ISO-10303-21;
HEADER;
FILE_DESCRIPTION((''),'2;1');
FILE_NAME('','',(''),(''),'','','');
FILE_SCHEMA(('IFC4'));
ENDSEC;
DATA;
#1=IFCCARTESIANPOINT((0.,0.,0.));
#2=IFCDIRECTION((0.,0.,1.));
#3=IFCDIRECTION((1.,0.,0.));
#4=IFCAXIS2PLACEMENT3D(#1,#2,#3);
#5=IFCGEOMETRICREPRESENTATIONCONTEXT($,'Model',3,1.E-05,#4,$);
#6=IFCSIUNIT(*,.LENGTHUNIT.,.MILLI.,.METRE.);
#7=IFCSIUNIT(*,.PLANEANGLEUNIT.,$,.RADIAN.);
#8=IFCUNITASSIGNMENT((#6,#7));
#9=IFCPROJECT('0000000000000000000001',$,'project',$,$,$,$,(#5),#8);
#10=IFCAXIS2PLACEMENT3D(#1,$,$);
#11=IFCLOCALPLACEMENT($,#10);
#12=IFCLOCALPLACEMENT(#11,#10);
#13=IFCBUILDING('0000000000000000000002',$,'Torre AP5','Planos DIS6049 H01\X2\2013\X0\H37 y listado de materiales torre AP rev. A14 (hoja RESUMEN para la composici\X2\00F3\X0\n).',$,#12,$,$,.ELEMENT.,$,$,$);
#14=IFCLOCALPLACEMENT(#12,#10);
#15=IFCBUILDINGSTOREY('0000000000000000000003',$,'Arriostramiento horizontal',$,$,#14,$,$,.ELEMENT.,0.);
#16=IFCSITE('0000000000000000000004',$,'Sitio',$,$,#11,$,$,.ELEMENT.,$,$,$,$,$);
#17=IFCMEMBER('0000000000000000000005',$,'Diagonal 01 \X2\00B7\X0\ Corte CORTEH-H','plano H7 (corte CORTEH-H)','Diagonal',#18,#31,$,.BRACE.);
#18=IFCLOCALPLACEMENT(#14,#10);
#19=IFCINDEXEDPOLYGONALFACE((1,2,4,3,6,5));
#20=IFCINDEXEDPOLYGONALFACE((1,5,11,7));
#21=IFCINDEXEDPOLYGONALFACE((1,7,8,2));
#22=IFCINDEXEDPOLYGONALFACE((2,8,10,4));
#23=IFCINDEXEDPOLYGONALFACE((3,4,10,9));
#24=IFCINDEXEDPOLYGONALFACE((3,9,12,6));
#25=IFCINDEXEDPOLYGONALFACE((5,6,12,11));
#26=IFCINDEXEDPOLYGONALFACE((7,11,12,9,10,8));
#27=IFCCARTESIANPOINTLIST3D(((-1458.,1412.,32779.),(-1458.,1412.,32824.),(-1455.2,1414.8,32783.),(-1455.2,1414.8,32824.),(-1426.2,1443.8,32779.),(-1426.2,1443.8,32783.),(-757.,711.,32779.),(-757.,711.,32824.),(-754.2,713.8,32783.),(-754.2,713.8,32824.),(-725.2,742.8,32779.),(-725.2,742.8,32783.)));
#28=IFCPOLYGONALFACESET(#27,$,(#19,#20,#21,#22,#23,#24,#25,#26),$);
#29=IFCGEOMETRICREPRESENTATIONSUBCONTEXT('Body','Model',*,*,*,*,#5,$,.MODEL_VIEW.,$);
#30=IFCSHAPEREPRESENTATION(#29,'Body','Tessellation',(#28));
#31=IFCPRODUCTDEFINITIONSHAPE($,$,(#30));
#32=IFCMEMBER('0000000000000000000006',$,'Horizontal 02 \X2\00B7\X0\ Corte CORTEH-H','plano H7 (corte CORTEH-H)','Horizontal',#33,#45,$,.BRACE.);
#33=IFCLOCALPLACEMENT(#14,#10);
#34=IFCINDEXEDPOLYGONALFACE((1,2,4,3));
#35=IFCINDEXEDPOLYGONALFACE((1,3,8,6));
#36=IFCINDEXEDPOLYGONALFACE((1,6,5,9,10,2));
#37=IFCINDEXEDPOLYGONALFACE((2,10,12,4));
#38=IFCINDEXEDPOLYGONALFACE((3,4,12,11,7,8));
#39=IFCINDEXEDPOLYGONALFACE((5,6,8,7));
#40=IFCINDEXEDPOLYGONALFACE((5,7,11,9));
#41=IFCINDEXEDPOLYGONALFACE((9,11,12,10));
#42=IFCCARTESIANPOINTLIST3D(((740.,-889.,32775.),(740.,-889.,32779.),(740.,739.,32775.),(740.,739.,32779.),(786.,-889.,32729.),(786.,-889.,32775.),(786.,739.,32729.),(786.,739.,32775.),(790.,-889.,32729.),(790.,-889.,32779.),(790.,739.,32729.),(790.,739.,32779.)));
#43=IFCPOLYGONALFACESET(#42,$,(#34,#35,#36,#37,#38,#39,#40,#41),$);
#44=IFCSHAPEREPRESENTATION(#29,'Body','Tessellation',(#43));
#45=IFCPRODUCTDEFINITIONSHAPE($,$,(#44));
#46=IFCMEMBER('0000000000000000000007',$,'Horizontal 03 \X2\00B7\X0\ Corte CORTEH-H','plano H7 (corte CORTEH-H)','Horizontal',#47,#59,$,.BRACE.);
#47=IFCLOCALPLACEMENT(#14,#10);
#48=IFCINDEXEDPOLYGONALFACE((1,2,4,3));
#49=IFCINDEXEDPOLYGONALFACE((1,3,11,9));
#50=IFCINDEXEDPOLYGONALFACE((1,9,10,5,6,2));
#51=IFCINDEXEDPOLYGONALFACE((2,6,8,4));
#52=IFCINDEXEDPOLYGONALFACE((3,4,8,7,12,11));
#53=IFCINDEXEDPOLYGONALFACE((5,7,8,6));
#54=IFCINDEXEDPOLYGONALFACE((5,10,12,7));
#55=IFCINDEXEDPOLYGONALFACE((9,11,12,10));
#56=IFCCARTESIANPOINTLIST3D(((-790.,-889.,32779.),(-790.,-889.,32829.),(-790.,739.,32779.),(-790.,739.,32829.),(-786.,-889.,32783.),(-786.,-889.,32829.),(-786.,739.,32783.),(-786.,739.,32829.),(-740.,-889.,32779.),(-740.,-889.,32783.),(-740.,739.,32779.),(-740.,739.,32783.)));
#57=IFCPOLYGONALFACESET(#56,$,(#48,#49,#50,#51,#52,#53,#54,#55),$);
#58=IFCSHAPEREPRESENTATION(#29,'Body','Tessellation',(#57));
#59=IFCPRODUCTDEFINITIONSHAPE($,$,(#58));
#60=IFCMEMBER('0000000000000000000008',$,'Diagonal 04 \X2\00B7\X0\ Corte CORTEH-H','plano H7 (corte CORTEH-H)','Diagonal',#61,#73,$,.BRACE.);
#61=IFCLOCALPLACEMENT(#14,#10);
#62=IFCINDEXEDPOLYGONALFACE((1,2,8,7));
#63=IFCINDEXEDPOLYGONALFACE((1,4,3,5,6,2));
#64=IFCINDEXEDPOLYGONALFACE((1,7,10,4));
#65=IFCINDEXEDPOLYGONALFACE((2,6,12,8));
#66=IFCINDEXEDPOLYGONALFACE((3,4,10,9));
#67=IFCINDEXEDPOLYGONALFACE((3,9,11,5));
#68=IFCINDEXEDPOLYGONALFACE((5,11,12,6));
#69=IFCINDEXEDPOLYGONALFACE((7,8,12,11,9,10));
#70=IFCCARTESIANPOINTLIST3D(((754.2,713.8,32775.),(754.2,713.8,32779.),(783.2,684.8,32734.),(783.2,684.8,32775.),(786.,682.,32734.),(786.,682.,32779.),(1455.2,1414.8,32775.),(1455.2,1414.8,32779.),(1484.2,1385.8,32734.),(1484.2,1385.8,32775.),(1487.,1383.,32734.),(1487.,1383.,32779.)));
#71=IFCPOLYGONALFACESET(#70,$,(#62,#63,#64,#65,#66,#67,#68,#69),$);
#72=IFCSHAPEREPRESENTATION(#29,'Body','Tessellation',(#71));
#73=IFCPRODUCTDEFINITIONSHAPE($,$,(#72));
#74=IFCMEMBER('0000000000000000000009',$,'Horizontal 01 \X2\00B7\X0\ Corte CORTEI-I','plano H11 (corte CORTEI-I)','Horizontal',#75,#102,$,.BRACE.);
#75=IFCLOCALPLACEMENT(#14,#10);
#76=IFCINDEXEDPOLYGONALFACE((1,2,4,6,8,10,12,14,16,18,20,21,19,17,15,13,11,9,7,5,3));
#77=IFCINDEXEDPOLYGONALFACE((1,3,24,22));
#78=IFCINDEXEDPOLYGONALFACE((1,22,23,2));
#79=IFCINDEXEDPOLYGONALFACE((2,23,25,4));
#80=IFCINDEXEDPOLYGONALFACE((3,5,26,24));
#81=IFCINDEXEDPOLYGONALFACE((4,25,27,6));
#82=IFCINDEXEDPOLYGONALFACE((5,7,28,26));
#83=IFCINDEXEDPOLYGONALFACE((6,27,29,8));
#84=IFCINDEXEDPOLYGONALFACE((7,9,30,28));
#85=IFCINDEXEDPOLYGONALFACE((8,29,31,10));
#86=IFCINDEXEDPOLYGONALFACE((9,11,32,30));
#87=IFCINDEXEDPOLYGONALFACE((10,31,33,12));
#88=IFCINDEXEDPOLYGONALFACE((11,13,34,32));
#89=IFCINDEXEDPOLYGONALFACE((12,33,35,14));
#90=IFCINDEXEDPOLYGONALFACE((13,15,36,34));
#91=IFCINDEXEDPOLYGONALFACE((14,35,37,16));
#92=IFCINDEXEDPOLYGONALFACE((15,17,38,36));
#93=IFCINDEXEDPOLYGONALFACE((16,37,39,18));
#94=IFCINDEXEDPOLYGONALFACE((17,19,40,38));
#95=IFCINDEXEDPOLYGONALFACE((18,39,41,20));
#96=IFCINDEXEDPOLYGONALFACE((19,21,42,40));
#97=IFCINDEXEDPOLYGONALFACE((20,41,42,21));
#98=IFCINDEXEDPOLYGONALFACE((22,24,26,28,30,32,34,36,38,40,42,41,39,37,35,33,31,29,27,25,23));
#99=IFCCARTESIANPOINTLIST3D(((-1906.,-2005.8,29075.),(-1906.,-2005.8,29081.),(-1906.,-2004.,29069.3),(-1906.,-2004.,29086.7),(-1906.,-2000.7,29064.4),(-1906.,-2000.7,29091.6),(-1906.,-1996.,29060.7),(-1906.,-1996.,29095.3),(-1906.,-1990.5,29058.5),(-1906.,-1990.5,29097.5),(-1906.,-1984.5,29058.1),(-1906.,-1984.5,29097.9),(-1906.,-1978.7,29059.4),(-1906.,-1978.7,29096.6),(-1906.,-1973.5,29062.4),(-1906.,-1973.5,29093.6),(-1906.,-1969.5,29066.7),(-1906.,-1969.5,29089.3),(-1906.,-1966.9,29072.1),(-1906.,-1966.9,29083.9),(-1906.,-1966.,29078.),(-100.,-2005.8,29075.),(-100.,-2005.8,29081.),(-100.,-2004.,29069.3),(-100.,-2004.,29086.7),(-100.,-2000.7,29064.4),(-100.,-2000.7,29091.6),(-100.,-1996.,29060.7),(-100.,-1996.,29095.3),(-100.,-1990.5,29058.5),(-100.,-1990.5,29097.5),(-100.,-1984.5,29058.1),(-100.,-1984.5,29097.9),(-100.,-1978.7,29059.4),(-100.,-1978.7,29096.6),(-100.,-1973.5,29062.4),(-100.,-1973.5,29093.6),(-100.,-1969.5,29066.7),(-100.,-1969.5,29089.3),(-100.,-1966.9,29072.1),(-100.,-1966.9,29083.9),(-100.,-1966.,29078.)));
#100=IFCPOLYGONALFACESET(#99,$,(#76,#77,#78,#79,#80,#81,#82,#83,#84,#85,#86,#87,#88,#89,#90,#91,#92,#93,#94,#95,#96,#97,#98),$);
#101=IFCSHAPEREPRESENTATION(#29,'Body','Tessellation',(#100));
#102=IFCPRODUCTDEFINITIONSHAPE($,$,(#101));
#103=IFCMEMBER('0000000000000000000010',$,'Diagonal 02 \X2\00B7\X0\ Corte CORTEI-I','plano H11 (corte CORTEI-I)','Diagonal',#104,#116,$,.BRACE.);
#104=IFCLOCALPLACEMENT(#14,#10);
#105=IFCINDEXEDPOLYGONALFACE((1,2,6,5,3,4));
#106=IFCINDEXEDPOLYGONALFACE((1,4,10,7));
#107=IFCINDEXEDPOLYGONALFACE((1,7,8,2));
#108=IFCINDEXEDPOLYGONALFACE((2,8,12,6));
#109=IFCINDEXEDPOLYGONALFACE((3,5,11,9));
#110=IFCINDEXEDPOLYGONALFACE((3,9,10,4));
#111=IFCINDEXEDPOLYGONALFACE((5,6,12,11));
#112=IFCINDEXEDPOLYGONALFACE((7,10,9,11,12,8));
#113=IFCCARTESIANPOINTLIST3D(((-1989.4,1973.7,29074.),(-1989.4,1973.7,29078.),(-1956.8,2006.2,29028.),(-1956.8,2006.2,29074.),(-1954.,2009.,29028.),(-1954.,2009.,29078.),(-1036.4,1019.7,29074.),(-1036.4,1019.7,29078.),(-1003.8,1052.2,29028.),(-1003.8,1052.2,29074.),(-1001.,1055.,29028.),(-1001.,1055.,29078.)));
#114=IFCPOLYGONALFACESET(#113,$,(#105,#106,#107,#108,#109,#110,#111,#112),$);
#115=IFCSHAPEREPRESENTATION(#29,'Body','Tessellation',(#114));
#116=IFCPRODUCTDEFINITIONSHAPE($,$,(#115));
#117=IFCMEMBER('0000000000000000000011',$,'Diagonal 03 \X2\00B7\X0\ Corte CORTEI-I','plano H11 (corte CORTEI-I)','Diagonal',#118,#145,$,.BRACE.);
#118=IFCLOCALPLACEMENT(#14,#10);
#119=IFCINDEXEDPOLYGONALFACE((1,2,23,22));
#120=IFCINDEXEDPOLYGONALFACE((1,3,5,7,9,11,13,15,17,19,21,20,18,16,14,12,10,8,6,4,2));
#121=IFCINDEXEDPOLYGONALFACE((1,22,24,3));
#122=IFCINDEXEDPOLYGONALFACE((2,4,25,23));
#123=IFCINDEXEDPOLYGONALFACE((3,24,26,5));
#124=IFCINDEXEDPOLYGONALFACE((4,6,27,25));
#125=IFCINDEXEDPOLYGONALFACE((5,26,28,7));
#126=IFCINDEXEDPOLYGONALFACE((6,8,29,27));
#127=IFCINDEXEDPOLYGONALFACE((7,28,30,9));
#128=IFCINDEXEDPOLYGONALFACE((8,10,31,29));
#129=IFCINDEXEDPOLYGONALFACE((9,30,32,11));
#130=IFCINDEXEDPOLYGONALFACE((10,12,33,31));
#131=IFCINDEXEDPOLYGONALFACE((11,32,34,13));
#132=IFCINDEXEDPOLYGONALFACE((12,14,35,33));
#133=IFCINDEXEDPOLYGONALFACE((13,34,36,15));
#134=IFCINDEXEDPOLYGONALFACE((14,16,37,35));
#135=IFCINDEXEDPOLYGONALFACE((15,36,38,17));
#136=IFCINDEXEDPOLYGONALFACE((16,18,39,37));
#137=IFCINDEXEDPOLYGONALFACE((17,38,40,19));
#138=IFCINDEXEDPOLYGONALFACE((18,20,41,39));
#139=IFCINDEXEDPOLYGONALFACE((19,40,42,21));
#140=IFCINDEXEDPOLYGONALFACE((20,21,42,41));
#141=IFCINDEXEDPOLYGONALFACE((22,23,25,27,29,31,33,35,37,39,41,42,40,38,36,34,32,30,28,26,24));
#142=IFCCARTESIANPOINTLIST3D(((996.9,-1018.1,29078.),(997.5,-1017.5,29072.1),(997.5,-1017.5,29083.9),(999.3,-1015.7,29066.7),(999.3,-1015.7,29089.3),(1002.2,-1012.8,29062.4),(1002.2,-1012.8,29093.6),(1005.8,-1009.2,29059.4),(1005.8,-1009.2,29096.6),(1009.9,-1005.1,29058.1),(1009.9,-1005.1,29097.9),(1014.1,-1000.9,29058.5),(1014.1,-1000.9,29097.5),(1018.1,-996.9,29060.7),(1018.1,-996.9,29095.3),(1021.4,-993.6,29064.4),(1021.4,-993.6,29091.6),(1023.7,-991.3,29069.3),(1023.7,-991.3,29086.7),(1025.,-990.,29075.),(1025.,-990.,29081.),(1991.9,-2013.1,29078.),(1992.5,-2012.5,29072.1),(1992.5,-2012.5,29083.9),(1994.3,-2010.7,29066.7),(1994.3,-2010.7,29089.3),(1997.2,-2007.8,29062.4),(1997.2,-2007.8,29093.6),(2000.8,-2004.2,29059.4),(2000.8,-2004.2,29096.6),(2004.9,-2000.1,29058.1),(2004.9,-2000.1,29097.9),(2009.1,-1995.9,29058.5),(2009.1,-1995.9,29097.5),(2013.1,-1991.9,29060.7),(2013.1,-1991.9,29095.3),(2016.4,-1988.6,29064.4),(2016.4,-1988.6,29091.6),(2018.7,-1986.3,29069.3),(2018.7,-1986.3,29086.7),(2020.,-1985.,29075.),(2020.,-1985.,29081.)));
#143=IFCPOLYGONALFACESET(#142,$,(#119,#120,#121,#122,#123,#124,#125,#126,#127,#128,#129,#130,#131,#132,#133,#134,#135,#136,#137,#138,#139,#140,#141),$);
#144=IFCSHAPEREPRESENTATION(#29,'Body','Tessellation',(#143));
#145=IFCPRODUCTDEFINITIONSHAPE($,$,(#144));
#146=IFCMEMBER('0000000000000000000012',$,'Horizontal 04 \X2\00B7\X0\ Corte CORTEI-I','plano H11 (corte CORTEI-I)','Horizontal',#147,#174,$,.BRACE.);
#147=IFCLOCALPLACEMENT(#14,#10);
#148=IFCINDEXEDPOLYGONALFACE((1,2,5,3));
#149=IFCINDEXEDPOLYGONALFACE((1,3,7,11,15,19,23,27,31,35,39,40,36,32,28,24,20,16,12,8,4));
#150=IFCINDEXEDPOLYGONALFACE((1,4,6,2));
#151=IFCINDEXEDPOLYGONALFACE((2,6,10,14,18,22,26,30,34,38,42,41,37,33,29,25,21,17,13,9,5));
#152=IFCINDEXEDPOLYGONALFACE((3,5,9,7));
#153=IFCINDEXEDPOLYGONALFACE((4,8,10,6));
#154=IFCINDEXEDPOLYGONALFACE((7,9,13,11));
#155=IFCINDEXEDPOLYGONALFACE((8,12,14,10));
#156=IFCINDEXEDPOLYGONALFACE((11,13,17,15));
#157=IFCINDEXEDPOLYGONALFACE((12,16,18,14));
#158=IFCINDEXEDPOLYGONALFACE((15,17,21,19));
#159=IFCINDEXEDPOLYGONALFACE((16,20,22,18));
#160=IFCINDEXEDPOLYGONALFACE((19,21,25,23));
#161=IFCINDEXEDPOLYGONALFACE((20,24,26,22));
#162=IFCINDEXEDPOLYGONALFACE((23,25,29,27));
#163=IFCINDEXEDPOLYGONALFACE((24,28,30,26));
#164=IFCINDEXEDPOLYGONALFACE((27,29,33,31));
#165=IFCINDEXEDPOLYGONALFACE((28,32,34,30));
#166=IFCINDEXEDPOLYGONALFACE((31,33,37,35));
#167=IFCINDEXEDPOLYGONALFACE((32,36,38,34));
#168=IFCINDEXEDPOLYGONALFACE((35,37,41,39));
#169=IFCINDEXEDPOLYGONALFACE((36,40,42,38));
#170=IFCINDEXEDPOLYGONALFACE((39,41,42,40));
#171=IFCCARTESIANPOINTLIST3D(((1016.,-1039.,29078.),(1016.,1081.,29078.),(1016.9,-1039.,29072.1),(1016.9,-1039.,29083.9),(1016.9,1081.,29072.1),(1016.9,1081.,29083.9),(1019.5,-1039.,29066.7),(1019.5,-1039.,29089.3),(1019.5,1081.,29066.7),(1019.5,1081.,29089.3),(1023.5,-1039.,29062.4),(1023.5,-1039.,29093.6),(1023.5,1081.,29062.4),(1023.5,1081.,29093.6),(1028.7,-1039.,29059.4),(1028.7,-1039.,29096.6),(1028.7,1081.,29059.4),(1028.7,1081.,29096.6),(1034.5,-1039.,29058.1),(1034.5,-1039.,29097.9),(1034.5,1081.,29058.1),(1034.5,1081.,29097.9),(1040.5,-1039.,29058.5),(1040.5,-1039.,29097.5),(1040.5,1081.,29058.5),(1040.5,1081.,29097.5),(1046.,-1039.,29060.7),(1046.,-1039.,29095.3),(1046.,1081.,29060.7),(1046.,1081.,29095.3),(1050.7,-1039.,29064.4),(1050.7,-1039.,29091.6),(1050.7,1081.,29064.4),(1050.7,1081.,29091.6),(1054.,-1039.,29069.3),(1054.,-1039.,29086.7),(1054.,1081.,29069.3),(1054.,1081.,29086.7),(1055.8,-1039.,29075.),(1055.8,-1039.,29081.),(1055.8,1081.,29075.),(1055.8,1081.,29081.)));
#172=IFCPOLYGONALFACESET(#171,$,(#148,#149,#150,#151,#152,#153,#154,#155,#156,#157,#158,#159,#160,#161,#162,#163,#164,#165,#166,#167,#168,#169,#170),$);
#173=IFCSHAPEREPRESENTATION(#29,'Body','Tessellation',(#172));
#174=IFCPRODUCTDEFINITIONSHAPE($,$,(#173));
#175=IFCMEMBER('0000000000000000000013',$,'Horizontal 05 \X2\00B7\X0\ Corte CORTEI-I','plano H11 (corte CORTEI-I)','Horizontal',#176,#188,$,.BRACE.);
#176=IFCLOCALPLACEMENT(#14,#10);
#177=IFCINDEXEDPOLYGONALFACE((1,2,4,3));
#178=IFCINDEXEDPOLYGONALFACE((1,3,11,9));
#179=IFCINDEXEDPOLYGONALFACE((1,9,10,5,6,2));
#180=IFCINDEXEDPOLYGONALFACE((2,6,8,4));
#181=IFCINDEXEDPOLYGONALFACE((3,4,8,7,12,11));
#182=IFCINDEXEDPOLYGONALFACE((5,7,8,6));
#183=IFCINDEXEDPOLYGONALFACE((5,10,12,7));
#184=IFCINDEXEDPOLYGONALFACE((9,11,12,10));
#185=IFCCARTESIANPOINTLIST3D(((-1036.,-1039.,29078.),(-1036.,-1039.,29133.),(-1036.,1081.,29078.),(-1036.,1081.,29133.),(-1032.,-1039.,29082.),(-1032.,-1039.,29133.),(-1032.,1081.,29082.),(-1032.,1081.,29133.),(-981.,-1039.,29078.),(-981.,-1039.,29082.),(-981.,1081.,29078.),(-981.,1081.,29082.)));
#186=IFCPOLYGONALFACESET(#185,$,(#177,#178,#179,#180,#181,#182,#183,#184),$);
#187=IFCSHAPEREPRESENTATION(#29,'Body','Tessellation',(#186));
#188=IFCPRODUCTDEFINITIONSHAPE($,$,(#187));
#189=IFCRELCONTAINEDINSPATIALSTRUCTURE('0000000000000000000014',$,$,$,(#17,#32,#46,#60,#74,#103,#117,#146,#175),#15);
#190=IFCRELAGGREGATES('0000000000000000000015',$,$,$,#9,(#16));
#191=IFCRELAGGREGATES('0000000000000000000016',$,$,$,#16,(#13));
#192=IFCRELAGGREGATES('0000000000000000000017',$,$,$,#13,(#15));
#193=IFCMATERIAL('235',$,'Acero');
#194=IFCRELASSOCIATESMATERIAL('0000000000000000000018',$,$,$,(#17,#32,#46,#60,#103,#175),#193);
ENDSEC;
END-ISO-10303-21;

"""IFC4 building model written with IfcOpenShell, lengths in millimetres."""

from ifc_helpers import new_model, si_unit, frame, frame_2d, origin, origin_with_axes, place, context, subcontext, project, spatial, circle, l_section, extrude, material, element, save


model = new_model("IFC4")

# Units and contexts
model_context = context("Model", 3, precision=1e-05, world=origin_with_axes())
body_context = subcontext(model_context, "Body", "Model", "MODEL_VIEW")
ifc_project = project(units=[si_unit("LENGTHUNIT", "METRE", prefix="MILLI"), si_unit("PLANEANGLEUNIT", "RADIAN")], contexts=[model_context])

# Site, building, storey
site_placement = place(None, origin())
site = spatial("IfcSite", under=ifc_project, at=site_placement, Name="Sitio", CompositionType="ELEMENT")
building_placement = place(site_placement, origin())
building = spatial("IfcBuilding", under=site, at=building_placement, Name="Torre AP5", Description="Planos DIS6049 H01–H37 y listado de materiales torre AP rev. A14 (hoja RESUMEN para la composición).", CompositionType="ELEMENT")
storey_placement = place(building_placement, origin())
storey = spatial("IfcBuildingStorey", under=building, at=storey_placement, Name="Arriostramiento horizontal", CompositionType="ELEMENT", Elevation=0.0)

# Members
ifc_material = material(Name="235", Category="Acero")
member_1_placement = place(storey_placement, frame((-1458.0, 1412.0, 32779.0), z_axis=(0.707107, -0.707107, 0.0), x_axis=(0.707107, 0.707107, 0.0)))
element("IfcMember", 1, at=member_1_placement, inside=storey, material=ifc_material, Name="Diagonal 01 · Corte CORTEH-H", Description="plano H7 (corte CORTEH-H)", ObjectType="Diagonal", PredefinedType="BRACE", context=body_context, shape_type="SweptSolid", body=[
    extrude(l_section(Depth=45.0, Width=45.0, Thickness=4.0, at=frame_2d((22.5, 22.5))), None, (0.0, 0.0, 1.0), 991.4),
])
for number, where, z_axis, x_axis, name in (
    (2, (790.0, 739.0, 32779.0), (0.0, -1.0, 0.0), (-1.0, 0.0, 0.0), "Horizontal 02 · Corte CORTEH-H"),
    (3, (-790.0, 739.0, 32779.0), (0.0, -1.0, 0.0), (1.0, 0.0, 0.0), "Horizontal 03 · Corte CORTEH-H"),
):
    element("IfcMember", number, at=place(storey_placement, frame(where, z_axis=z_axis, x_axis=x_axis)), inside=storey, material=ifc_material, Name=name, Description="plano H7 (corte CORTEH-H)", ObjectType="Horizontal", PredefinedType="BRACE", context=body_context, shape_type="SweptSolid", body=[
        extrude(l_section(Depth=50.0, Width=50.0, Thickness=4.0, at=frame_2d((25.0, 25.0))), None, (0.0, 0.0, 1.0), 1628.0),
    ])
member_2_placement = place(storey_placement, frame((1487.0, 1383.0, 32779.0), z_axis=(-0.707107, -0.707107, 0.0), x_axis=(-0.707107, 0.707107, 0.0)))
element("IfcMember", 4, at=member_2_placement, inside=storey, material=ifc_material, Name="Diagonal 04 · Corte CORTEH-H", Description="plano H7 (corte CORTEH-H)", ObjectType="Diagonal", PredefinedType="BRACE", context=body_context, shape_type="SweptSolid", body=[
    extrude(l_section(Depth=45.0, Width=45.0, Thickness=4.0, at=frame_2d((22.5, 22.5))), None, (0.0, 0.0, 1.0), 991.4),
])
member_3_placement = place(storey_placement, frame((-1906.0, -1986.0, 29078.0), z_axis=(1.0, 0.0, 0.0), x_axis=(0.0, 1.0, 0.0)))
element("IfcMember", 5, at=member_3_placement, inside=storey, Name="Horizontal 01 · Corte CORTEI-I", Description="plano H11 (corte CORTEI-I)", ObjectType="Horizontal", PredefinedType="BRACE", context=body_context, shape_type="SweptSolid", body=[
    extrude(circle(Radius=20.0), None, (0.0, 0.0, 1.0), 1806.0),
])
member_4_placement = place(storey_placement, frame((-1954.0, 2009.0, 29078.0), z_axis=(0.706736, -0.707477, 0.0), x_axis=(-0.707477, -0.706736, 0.0)))
element("IfcMember", 6, at=member_4_placement, inside=storey, material=ifc_material, Name="Diagonal 02 · Corte CORTEI-I", Description="plano H11 (corte CORTEI-I)", ObjectType="Diagonal", PredefinedType="BRACE", context=body_context, shape_type="SweptSolid", body=[
    extrude(l_section(Depth=50.0, Width=50.0, Thickness=4.0, at=frame_2d((25.0, 25.0))), None, (0.0, 0.0, 1.0), 1348.5),
])
member_5_placement = place(storey_placement, frame((1011.0, -1004.0, 29078.0), z_axis=(0.707107, -0.707107, 0.0), x_axis=(-0.707107, -0.707107, 0.0)))
element("IfcMember", 7, at=member_5_placement, inside=storey, Name="Diagonal 03 · Corte CORTEI-I", Description="plano H11 (corte CORTEI-I)", ObjectType="Diagonal", PredefinedType="BRACE", context=body_context, shape_type="SweptSolid", body=[
    extrude(circle(Radius=20.0), None, (0.0, 0.0, 1.0), 1407.1),
])
member_6_placement = place(storey_placement, frame((1036.0, 1081.0, 29078.0), z_axis=(0.0, -1.0, 0.0), x_axis=(-1.0, 0.0, 0.0)))
element("IfcMember", 8, at=member_6_placement, inside=storey, Name="Horizontal 04 · Corte CORTEI-I", Description="plano H11 (corte CORTEI-I)", ObjectType="Horizontal", PredefinedType="BRACE", context=body_context, shape_type="SweptSolid", body=[
    extrude(circle(Radius=20.0), None, (0.0, 0.0, 1.0), 2120.0),
])
member_7_placement = place(storey_placement, frame((-1036.0, 1081.0, 29078.0), z_axis=(0.0, -1.0, 0.0), x_axis=(1.0, 0.0, 0.0)))
element("IfcMember", 9, at=member_7_placement, inside=storey, material=ifc_material, Name="Horizontal 05 · Corte CORTEI-I", Description="plano H11 (corte CORTEI-I)", ObjectType="Horizontal", PredefinedType="BRACE", context=body_context, shape_type="SweptSolid", body=[
    extrude(l_section(Depth=55.0, Width=55.0, Thickness=4.0, at=frame_2d((27.5, 27.5))), None, (0.0, 0.0, 1.0), 2120.0),
])

save(model, "model.ifc")
